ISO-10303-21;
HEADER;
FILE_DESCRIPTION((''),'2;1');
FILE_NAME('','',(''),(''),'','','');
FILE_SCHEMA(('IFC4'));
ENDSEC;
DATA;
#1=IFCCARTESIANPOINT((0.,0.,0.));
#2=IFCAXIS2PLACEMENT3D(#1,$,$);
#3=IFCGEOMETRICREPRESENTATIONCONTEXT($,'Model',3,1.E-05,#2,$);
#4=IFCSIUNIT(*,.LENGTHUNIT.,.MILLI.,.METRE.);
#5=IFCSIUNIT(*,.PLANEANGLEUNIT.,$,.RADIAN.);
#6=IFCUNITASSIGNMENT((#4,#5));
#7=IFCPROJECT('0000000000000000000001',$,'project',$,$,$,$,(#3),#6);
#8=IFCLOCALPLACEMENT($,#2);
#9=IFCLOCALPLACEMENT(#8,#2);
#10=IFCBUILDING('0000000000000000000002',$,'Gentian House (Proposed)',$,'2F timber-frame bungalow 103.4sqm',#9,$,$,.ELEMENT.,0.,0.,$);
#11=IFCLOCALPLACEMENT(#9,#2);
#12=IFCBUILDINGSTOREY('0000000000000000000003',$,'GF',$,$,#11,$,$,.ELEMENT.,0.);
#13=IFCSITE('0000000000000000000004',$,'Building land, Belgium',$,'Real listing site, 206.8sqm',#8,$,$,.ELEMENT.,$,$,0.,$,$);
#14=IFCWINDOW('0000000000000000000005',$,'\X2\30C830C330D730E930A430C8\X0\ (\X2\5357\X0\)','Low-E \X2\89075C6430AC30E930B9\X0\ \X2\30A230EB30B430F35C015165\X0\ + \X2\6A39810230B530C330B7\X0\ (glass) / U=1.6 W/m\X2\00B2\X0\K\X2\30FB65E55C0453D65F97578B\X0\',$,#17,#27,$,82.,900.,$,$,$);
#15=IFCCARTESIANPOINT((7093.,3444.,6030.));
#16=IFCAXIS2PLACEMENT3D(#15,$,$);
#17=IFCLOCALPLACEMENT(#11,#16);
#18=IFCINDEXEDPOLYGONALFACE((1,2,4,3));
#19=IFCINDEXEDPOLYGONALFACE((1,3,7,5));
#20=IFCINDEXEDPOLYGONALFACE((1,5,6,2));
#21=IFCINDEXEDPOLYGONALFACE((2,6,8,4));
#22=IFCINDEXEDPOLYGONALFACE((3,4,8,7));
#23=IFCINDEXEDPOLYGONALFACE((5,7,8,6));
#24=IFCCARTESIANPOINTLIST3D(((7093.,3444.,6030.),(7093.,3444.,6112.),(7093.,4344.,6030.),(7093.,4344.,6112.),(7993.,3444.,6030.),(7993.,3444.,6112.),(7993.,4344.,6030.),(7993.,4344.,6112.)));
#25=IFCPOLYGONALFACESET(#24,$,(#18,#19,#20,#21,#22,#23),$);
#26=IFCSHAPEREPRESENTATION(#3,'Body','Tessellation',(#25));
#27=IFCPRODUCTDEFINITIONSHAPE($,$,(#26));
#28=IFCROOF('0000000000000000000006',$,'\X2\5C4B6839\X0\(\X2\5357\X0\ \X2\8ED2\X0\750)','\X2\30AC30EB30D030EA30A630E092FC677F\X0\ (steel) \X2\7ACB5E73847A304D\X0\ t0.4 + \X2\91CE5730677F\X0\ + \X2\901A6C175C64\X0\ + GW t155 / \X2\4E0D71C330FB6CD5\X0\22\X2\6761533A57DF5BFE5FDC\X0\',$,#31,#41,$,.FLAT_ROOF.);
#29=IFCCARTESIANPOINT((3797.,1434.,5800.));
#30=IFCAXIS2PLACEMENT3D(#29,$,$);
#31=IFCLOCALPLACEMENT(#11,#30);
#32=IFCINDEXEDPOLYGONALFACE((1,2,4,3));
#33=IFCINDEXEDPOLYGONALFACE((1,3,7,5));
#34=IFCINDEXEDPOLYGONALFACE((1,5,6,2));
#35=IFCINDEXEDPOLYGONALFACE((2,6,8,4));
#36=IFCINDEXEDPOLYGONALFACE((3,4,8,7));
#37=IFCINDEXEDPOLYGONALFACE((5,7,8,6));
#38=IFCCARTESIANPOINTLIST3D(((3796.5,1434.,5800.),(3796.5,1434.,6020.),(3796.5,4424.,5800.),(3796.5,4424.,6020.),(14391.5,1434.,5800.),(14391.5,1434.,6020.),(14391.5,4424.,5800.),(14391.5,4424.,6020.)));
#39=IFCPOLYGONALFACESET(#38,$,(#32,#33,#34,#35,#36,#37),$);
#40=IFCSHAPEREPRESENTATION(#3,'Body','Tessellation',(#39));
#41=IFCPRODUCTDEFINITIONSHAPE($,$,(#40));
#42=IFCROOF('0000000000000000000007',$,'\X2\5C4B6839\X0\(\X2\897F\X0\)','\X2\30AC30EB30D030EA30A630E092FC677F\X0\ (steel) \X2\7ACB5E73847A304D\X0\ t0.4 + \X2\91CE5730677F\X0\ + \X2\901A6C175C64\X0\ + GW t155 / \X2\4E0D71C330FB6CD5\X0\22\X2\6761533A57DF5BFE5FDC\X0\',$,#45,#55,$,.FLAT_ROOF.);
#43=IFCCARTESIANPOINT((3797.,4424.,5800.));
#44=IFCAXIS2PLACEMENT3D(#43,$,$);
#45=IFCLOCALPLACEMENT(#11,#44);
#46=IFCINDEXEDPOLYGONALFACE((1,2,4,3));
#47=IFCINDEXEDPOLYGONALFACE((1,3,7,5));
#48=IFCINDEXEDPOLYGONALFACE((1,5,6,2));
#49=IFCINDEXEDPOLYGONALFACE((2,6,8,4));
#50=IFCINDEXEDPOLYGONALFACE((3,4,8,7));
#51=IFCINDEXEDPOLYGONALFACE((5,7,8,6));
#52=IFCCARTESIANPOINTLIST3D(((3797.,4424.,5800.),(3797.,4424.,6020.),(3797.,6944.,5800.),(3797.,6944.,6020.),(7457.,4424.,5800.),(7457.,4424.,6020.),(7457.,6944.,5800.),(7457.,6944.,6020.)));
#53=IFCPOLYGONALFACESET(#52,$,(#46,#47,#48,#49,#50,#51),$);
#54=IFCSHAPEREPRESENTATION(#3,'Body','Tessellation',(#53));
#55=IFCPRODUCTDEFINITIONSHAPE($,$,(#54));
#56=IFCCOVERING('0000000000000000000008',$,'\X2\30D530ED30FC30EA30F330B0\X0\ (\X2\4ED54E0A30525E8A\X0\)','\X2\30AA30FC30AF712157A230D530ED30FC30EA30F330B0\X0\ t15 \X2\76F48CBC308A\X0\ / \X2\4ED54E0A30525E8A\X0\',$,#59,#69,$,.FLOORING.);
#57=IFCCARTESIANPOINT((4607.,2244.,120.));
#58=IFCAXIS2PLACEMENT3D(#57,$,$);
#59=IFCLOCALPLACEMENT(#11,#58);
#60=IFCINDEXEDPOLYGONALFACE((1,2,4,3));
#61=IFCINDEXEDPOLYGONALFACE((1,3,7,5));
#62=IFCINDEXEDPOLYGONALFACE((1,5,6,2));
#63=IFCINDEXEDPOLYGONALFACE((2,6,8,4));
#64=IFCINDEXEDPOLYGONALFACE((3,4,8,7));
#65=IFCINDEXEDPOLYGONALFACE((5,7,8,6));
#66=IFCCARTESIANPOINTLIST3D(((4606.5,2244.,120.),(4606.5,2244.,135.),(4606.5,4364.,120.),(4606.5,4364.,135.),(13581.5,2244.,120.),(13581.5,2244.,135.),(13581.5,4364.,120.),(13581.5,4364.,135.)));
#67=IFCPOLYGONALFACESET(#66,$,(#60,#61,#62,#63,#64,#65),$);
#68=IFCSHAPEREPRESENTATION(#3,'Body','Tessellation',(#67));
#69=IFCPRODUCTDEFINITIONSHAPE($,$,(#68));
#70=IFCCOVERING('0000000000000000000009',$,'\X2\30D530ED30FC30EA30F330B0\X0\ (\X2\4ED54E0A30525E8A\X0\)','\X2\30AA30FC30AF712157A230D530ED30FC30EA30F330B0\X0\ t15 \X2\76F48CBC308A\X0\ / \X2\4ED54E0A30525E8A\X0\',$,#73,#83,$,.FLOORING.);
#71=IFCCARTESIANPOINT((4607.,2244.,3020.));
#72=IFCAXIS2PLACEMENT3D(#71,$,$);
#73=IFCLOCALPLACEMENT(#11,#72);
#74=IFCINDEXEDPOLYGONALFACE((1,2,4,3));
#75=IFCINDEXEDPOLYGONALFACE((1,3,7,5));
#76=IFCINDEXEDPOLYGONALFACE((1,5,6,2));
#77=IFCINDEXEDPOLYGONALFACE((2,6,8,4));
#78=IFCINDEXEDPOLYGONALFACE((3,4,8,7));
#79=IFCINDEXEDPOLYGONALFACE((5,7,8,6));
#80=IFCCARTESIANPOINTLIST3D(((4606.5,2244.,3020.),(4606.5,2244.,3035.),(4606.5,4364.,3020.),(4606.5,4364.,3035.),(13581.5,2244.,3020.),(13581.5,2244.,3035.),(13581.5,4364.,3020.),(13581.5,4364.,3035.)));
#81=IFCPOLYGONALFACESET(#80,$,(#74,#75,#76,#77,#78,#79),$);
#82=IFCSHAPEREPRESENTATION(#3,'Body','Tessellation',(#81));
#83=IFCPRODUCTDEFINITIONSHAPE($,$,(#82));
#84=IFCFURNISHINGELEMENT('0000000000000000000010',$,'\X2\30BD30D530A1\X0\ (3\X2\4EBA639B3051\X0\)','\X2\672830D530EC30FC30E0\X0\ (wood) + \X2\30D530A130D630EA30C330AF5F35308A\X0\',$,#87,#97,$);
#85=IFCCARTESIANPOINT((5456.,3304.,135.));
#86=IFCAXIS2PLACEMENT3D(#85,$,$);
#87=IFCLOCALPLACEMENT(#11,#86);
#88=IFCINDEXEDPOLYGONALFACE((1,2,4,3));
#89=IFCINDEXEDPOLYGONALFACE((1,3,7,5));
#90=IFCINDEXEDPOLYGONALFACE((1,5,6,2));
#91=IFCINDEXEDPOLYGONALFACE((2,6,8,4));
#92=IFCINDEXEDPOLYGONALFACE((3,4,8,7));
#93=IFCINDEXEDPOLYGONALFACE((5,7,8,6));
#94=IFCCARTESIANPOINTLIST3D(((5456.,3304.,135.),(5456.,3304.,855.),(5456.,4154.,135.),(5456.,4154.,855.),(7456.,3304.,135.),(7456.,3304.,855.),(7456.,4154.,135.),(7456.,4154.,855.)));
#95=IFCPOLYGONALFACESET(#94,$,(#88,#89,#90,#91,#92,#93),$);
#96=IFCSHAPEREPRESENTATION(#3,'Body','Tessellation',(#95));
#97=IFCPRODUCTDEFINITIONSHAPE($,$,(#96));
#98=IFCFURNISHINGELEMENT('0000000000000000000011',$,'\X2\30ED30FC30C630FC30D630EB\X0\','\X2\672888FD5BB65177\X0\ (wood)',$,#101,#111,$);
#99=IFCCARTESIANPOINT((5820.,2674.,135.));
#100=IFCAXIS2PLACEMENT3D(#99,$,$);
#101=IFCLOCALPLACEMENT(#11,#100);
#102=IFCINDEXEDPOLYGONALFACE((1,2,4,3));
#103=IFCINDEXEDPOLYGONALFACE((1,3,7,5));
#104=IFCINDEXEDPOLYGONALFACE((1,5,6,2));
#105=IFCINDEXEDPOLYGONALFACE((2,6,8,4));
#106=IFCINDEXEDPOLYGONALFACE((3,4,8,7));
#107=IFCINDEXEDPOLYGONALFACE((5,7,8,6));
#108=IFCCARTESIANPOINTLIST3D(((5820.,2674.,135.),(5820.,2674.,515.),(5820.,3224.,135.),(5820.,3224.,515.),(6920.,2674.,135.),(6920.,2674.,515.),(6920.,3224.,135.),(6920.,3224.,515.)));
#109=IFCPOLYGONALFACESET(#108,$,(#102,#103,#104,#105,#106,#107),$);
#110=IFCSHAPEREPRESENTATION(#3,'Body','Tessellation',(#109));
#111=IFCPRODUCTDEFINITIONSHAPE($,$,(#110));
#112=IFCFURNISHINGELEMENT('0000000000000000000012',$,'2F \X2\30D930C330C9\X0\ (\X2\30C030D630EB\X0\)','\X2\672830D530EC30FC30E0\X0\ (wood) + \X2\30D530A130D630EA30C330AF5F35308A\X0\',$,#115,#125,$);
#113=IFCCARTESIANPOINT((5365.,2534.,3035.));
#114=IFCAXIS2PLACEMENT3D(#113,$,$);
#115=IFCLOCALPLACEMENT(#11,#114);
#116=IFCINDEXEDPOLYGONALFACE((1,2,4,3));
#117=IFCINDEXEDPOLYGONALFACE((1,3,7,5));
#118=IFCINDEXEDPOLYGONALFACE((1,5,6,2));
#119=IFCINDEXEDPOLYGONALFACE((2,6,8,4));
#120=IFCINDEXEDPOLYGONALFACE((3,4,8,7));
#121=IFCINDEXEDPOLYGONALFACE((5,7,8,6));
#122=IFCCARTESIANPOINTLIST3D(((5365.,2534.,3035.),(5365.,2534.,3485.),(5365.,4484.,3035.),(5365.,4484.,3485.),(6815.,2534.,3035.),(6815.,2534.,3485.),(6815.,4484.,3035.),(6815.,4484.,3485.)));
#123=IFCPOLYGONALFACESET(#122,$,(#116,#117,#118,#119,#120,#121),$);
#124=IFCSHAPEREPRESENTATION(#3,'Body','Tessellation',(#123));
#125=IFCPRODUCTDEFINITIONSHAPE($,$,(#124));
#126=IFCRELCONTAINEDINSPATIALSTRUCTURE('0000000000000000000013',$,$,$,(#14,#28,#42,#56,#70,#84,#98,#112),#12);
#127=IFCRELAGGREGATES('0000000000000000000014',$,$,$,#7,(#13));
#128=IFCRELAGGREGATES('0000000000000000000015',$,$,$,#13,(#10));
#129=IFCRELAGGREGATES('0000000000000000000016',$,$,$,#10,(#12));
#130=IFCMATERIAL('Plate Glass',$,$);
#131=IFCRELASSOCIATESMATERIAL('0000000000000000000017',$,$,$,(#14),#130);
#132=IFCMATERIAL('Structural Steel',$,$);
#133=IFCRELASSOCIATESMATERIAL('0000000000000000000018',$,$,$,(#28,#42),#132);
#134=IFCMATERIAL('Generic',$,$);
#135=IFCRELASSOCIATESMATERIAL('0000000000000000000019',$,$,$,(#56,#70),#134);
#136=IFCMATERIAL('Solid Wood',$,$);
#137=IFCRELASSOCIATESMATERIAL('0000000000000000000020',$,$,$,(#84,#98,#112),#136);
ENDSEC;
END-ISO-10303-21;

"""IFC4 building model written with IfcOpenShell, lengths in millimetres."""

from ifc_helpers import new_model, si_unit, frame, frame_2d, origin, place, context, project, spatial, rectangle, extrude, material, element, save


model = new_model("IFC4")

# Units and contexts
model_context = context("Model", 3, precision=1e-05, world=origin())
ifc_project = project(units=[si_unit("LENGTHUNIT", "METRE", prefix="MILLI"), si_unit("PLANEANGLEUNIT", "RADIAN")], contexts=[model_context])

# Site, building, storey
site_placement = place(None, origin())
site = spatial("IfcSite", under=ifc_project, at=site_placement, Name="Building land, Belgium", ObjectType="Real listing site, 206.8sqm", CompositionType="ELEMENT", RefElevation=0.0)
building_placement = place(site_placement, origin())
building = spatial("IfcBuilding", under=site, at=building_placement, Name="Gentian House (Proposed)", ObjectType="2F timber-frame bungalow 103.4sqm", CompositionType="ELEMENT", ElevationOfRefHeight=0.0, ElevationOfTerrain=0.0)
storey_placement = place(building_placement, origin())
storey = spatial("IfcBuildingStorey", under=building, at=storey_placement, Name="GF", CompositionType="ELEMENT", Elevation=0.0)

# Shared definitions
ifc_material_1 = material(Name="Solid Wood")

# Shared definitions
ifc_material_2 = material(Name="Plate Glass")

# Window
window_1_placement = place(storey_placement, frame((7093.0, 3444.0, 6030.0)))
element("IfcWindow", 1, at=window_1_placement, inside=storey, material=ifc_material_2, Name="トップライト (南)", Description="Low-E 複層ガラス アルゴン封入 + 樹脂サッシ (glass) / U=1.6 W/m²K・日射取得型", OverallHeight=82.0, OverallWidth=900.0, context=model_context, shape_type="SweptSolid", body=[
    extrude(rectangle(XDim=900.0, YDim=900.0, at=frame_2d((450.0, 450.0))), frame((7093.0, 3444.0, 6030.0)), (0.0, 0.0, 1.0), 82.0),
])

# Roofs
ifc_material_3 = material(Name="Structural Steel")
roof_1_placement = place(storey_placement, frame((3797.0, 1434.0, 5800.0)))
element("IfcRoof", 2, at=roof_1_placement, inside=storey, material=ifc_material_3, Name="屋根(南 軒750)", Description="ガルバリウム鋼板 (steel) 立平葺き t0.4 + 野地板 + 通気層 + GW t155 / 不燃・法22条区域対応", PredefinedType="FLAT_ROOF", context=model_context, shape_type="SweptSolid", body=[
    extrude(rectangle(XDim=10595.0, YDim=2990.0, at=frame_2d((5297.0, 1495.0))), frame((3797.0, 1434.0, 5800.0)), (0.0, 0.0, 1.0), 220.0),
])
roof_2_placement = place(storey_placement, frame((3797.0, 4424.0, 5800.0)))
element("IfcRoof", 3, at=roof_2_placement, inside=storey, material=ifc_material_3, Name="屋根(西)", Description="ガルバリウム鋼板 (steel) 立平葺き t0.4 + 野地板 + 通気層 + GW t155 / 不燃・法22条区域対応", PredefinedType="FLAT_ROOF", context=model_context, shape_type="SweptSolid", body=[
    extrude(rectangle(XDim=3660.0, YDim=2520.0, at=frame_2d((1830.0, 1260.0))), frame((3797.0, 4424.0, 5800.0)), (0.0, 0.0, 1.0), 220.0),
])

# Coverings
ifc_material_4 = material(Name="Generic")
covering_1_placement = place(storey_placement, frame((4607.0, 2244.0, 120.0)))
element("IfcCovering", 4, at=covering_1_placement, inside=storey, material=ifc_material_4, Name="フローリング (仕上げ床)", Description="オーク無垢フローリング t15 直貼り / 仕上げ床", PredefinedType="FLOORING", context=model_context, shape_type="SweptSolid", body=[
    extrude(rectangle(XDim=8975.0, YDim=2120.0, at=frame_2d((4487.0, 1060.0))), frame((4607.0, 2244.0, 120.0)), (0.0, 0.0, 1.0), 15.0),
])
covering_2_placement = place(storey_placement, frame((4607.0, 2244.0, 3020.0)))
element("IfcCovering", 5, at=covering_2_placement, inside=storey, material=ifc_material_4, Name="フローリング (仕上げ床)", Description="オーク無垢フローリング t15 直貼り / 仕上げ床", PredefinedType="FLOORING", context=model_context, shape_type="SweptSolid", body=[
    extrude(rectangle(XDim=8975.0, YDim=2120.0, at=frame_2d((4487.0, 1060.0))), frame((4607.0, 2244.0, 3020.0)), (0.0, 0.0, 1.0), 15.0),
])

# Furnishing elements
furnishing_1_placement = place(storey_placement, frame((5456.0, 3304.0, 135.0)))
element("IfcFurnishingElement", 6, at=furnishing_1_placement, inside=storey, material=ifc_material_1, Name="ソファ (3人掛け)", Description="木フレーム (wood) + ファブリック張り", context=model_context, shape_type="SweptSolid", body=[
    extrude(rectangle(XDim=2000.0, YDim=850.0, at=frame_2d((1000.0, 425.0))), frame((5456.0, 3304.0, 135.0)), (0.0, 0.0, 1.0), 720.0),
])
furnishing_2_placement = place(storey_placement, frame((5820.0, 2674.0, 135.0)))
element("IfcFurnishingElement", 7, at=furnishing_2_placement, inside=storey, material=ifc_material_1, Name="ローテーブル", Description="木製家具 (wood)", context=model_context, shape_type="SweptSolid", body=[
    extrude(rectangle(XDim=1100.0, YDim=550.0, at=frame_2d((550.0, 275.0))), frame((5820.0, 2674.0, 135.0)), (0.0, 0.0, 1.0), 380.0),
])
furnishing_3_placement = place(storey_placement, frame((5365.0, 2534.0, 3035.0)))
element("IfcFurnishingElement", 8, at=furnishing_3_placement, inside=storey, material=ifc_material_1, Name="2F ベッド (ダブル)", Description="木フレーム (wood) + ファブリック張り", context=model_context, shape_type="SweptSolid", body=[
    extrude(rectangle(XDim=1450.0, YDim=1950.0, at=frame_2d((725.0, 975.0))), frame((5365.0, 2534.0, 3035.0)), (0.0, 0.0, 1.0), 450.0),
])

save(model, "model.ifc")
